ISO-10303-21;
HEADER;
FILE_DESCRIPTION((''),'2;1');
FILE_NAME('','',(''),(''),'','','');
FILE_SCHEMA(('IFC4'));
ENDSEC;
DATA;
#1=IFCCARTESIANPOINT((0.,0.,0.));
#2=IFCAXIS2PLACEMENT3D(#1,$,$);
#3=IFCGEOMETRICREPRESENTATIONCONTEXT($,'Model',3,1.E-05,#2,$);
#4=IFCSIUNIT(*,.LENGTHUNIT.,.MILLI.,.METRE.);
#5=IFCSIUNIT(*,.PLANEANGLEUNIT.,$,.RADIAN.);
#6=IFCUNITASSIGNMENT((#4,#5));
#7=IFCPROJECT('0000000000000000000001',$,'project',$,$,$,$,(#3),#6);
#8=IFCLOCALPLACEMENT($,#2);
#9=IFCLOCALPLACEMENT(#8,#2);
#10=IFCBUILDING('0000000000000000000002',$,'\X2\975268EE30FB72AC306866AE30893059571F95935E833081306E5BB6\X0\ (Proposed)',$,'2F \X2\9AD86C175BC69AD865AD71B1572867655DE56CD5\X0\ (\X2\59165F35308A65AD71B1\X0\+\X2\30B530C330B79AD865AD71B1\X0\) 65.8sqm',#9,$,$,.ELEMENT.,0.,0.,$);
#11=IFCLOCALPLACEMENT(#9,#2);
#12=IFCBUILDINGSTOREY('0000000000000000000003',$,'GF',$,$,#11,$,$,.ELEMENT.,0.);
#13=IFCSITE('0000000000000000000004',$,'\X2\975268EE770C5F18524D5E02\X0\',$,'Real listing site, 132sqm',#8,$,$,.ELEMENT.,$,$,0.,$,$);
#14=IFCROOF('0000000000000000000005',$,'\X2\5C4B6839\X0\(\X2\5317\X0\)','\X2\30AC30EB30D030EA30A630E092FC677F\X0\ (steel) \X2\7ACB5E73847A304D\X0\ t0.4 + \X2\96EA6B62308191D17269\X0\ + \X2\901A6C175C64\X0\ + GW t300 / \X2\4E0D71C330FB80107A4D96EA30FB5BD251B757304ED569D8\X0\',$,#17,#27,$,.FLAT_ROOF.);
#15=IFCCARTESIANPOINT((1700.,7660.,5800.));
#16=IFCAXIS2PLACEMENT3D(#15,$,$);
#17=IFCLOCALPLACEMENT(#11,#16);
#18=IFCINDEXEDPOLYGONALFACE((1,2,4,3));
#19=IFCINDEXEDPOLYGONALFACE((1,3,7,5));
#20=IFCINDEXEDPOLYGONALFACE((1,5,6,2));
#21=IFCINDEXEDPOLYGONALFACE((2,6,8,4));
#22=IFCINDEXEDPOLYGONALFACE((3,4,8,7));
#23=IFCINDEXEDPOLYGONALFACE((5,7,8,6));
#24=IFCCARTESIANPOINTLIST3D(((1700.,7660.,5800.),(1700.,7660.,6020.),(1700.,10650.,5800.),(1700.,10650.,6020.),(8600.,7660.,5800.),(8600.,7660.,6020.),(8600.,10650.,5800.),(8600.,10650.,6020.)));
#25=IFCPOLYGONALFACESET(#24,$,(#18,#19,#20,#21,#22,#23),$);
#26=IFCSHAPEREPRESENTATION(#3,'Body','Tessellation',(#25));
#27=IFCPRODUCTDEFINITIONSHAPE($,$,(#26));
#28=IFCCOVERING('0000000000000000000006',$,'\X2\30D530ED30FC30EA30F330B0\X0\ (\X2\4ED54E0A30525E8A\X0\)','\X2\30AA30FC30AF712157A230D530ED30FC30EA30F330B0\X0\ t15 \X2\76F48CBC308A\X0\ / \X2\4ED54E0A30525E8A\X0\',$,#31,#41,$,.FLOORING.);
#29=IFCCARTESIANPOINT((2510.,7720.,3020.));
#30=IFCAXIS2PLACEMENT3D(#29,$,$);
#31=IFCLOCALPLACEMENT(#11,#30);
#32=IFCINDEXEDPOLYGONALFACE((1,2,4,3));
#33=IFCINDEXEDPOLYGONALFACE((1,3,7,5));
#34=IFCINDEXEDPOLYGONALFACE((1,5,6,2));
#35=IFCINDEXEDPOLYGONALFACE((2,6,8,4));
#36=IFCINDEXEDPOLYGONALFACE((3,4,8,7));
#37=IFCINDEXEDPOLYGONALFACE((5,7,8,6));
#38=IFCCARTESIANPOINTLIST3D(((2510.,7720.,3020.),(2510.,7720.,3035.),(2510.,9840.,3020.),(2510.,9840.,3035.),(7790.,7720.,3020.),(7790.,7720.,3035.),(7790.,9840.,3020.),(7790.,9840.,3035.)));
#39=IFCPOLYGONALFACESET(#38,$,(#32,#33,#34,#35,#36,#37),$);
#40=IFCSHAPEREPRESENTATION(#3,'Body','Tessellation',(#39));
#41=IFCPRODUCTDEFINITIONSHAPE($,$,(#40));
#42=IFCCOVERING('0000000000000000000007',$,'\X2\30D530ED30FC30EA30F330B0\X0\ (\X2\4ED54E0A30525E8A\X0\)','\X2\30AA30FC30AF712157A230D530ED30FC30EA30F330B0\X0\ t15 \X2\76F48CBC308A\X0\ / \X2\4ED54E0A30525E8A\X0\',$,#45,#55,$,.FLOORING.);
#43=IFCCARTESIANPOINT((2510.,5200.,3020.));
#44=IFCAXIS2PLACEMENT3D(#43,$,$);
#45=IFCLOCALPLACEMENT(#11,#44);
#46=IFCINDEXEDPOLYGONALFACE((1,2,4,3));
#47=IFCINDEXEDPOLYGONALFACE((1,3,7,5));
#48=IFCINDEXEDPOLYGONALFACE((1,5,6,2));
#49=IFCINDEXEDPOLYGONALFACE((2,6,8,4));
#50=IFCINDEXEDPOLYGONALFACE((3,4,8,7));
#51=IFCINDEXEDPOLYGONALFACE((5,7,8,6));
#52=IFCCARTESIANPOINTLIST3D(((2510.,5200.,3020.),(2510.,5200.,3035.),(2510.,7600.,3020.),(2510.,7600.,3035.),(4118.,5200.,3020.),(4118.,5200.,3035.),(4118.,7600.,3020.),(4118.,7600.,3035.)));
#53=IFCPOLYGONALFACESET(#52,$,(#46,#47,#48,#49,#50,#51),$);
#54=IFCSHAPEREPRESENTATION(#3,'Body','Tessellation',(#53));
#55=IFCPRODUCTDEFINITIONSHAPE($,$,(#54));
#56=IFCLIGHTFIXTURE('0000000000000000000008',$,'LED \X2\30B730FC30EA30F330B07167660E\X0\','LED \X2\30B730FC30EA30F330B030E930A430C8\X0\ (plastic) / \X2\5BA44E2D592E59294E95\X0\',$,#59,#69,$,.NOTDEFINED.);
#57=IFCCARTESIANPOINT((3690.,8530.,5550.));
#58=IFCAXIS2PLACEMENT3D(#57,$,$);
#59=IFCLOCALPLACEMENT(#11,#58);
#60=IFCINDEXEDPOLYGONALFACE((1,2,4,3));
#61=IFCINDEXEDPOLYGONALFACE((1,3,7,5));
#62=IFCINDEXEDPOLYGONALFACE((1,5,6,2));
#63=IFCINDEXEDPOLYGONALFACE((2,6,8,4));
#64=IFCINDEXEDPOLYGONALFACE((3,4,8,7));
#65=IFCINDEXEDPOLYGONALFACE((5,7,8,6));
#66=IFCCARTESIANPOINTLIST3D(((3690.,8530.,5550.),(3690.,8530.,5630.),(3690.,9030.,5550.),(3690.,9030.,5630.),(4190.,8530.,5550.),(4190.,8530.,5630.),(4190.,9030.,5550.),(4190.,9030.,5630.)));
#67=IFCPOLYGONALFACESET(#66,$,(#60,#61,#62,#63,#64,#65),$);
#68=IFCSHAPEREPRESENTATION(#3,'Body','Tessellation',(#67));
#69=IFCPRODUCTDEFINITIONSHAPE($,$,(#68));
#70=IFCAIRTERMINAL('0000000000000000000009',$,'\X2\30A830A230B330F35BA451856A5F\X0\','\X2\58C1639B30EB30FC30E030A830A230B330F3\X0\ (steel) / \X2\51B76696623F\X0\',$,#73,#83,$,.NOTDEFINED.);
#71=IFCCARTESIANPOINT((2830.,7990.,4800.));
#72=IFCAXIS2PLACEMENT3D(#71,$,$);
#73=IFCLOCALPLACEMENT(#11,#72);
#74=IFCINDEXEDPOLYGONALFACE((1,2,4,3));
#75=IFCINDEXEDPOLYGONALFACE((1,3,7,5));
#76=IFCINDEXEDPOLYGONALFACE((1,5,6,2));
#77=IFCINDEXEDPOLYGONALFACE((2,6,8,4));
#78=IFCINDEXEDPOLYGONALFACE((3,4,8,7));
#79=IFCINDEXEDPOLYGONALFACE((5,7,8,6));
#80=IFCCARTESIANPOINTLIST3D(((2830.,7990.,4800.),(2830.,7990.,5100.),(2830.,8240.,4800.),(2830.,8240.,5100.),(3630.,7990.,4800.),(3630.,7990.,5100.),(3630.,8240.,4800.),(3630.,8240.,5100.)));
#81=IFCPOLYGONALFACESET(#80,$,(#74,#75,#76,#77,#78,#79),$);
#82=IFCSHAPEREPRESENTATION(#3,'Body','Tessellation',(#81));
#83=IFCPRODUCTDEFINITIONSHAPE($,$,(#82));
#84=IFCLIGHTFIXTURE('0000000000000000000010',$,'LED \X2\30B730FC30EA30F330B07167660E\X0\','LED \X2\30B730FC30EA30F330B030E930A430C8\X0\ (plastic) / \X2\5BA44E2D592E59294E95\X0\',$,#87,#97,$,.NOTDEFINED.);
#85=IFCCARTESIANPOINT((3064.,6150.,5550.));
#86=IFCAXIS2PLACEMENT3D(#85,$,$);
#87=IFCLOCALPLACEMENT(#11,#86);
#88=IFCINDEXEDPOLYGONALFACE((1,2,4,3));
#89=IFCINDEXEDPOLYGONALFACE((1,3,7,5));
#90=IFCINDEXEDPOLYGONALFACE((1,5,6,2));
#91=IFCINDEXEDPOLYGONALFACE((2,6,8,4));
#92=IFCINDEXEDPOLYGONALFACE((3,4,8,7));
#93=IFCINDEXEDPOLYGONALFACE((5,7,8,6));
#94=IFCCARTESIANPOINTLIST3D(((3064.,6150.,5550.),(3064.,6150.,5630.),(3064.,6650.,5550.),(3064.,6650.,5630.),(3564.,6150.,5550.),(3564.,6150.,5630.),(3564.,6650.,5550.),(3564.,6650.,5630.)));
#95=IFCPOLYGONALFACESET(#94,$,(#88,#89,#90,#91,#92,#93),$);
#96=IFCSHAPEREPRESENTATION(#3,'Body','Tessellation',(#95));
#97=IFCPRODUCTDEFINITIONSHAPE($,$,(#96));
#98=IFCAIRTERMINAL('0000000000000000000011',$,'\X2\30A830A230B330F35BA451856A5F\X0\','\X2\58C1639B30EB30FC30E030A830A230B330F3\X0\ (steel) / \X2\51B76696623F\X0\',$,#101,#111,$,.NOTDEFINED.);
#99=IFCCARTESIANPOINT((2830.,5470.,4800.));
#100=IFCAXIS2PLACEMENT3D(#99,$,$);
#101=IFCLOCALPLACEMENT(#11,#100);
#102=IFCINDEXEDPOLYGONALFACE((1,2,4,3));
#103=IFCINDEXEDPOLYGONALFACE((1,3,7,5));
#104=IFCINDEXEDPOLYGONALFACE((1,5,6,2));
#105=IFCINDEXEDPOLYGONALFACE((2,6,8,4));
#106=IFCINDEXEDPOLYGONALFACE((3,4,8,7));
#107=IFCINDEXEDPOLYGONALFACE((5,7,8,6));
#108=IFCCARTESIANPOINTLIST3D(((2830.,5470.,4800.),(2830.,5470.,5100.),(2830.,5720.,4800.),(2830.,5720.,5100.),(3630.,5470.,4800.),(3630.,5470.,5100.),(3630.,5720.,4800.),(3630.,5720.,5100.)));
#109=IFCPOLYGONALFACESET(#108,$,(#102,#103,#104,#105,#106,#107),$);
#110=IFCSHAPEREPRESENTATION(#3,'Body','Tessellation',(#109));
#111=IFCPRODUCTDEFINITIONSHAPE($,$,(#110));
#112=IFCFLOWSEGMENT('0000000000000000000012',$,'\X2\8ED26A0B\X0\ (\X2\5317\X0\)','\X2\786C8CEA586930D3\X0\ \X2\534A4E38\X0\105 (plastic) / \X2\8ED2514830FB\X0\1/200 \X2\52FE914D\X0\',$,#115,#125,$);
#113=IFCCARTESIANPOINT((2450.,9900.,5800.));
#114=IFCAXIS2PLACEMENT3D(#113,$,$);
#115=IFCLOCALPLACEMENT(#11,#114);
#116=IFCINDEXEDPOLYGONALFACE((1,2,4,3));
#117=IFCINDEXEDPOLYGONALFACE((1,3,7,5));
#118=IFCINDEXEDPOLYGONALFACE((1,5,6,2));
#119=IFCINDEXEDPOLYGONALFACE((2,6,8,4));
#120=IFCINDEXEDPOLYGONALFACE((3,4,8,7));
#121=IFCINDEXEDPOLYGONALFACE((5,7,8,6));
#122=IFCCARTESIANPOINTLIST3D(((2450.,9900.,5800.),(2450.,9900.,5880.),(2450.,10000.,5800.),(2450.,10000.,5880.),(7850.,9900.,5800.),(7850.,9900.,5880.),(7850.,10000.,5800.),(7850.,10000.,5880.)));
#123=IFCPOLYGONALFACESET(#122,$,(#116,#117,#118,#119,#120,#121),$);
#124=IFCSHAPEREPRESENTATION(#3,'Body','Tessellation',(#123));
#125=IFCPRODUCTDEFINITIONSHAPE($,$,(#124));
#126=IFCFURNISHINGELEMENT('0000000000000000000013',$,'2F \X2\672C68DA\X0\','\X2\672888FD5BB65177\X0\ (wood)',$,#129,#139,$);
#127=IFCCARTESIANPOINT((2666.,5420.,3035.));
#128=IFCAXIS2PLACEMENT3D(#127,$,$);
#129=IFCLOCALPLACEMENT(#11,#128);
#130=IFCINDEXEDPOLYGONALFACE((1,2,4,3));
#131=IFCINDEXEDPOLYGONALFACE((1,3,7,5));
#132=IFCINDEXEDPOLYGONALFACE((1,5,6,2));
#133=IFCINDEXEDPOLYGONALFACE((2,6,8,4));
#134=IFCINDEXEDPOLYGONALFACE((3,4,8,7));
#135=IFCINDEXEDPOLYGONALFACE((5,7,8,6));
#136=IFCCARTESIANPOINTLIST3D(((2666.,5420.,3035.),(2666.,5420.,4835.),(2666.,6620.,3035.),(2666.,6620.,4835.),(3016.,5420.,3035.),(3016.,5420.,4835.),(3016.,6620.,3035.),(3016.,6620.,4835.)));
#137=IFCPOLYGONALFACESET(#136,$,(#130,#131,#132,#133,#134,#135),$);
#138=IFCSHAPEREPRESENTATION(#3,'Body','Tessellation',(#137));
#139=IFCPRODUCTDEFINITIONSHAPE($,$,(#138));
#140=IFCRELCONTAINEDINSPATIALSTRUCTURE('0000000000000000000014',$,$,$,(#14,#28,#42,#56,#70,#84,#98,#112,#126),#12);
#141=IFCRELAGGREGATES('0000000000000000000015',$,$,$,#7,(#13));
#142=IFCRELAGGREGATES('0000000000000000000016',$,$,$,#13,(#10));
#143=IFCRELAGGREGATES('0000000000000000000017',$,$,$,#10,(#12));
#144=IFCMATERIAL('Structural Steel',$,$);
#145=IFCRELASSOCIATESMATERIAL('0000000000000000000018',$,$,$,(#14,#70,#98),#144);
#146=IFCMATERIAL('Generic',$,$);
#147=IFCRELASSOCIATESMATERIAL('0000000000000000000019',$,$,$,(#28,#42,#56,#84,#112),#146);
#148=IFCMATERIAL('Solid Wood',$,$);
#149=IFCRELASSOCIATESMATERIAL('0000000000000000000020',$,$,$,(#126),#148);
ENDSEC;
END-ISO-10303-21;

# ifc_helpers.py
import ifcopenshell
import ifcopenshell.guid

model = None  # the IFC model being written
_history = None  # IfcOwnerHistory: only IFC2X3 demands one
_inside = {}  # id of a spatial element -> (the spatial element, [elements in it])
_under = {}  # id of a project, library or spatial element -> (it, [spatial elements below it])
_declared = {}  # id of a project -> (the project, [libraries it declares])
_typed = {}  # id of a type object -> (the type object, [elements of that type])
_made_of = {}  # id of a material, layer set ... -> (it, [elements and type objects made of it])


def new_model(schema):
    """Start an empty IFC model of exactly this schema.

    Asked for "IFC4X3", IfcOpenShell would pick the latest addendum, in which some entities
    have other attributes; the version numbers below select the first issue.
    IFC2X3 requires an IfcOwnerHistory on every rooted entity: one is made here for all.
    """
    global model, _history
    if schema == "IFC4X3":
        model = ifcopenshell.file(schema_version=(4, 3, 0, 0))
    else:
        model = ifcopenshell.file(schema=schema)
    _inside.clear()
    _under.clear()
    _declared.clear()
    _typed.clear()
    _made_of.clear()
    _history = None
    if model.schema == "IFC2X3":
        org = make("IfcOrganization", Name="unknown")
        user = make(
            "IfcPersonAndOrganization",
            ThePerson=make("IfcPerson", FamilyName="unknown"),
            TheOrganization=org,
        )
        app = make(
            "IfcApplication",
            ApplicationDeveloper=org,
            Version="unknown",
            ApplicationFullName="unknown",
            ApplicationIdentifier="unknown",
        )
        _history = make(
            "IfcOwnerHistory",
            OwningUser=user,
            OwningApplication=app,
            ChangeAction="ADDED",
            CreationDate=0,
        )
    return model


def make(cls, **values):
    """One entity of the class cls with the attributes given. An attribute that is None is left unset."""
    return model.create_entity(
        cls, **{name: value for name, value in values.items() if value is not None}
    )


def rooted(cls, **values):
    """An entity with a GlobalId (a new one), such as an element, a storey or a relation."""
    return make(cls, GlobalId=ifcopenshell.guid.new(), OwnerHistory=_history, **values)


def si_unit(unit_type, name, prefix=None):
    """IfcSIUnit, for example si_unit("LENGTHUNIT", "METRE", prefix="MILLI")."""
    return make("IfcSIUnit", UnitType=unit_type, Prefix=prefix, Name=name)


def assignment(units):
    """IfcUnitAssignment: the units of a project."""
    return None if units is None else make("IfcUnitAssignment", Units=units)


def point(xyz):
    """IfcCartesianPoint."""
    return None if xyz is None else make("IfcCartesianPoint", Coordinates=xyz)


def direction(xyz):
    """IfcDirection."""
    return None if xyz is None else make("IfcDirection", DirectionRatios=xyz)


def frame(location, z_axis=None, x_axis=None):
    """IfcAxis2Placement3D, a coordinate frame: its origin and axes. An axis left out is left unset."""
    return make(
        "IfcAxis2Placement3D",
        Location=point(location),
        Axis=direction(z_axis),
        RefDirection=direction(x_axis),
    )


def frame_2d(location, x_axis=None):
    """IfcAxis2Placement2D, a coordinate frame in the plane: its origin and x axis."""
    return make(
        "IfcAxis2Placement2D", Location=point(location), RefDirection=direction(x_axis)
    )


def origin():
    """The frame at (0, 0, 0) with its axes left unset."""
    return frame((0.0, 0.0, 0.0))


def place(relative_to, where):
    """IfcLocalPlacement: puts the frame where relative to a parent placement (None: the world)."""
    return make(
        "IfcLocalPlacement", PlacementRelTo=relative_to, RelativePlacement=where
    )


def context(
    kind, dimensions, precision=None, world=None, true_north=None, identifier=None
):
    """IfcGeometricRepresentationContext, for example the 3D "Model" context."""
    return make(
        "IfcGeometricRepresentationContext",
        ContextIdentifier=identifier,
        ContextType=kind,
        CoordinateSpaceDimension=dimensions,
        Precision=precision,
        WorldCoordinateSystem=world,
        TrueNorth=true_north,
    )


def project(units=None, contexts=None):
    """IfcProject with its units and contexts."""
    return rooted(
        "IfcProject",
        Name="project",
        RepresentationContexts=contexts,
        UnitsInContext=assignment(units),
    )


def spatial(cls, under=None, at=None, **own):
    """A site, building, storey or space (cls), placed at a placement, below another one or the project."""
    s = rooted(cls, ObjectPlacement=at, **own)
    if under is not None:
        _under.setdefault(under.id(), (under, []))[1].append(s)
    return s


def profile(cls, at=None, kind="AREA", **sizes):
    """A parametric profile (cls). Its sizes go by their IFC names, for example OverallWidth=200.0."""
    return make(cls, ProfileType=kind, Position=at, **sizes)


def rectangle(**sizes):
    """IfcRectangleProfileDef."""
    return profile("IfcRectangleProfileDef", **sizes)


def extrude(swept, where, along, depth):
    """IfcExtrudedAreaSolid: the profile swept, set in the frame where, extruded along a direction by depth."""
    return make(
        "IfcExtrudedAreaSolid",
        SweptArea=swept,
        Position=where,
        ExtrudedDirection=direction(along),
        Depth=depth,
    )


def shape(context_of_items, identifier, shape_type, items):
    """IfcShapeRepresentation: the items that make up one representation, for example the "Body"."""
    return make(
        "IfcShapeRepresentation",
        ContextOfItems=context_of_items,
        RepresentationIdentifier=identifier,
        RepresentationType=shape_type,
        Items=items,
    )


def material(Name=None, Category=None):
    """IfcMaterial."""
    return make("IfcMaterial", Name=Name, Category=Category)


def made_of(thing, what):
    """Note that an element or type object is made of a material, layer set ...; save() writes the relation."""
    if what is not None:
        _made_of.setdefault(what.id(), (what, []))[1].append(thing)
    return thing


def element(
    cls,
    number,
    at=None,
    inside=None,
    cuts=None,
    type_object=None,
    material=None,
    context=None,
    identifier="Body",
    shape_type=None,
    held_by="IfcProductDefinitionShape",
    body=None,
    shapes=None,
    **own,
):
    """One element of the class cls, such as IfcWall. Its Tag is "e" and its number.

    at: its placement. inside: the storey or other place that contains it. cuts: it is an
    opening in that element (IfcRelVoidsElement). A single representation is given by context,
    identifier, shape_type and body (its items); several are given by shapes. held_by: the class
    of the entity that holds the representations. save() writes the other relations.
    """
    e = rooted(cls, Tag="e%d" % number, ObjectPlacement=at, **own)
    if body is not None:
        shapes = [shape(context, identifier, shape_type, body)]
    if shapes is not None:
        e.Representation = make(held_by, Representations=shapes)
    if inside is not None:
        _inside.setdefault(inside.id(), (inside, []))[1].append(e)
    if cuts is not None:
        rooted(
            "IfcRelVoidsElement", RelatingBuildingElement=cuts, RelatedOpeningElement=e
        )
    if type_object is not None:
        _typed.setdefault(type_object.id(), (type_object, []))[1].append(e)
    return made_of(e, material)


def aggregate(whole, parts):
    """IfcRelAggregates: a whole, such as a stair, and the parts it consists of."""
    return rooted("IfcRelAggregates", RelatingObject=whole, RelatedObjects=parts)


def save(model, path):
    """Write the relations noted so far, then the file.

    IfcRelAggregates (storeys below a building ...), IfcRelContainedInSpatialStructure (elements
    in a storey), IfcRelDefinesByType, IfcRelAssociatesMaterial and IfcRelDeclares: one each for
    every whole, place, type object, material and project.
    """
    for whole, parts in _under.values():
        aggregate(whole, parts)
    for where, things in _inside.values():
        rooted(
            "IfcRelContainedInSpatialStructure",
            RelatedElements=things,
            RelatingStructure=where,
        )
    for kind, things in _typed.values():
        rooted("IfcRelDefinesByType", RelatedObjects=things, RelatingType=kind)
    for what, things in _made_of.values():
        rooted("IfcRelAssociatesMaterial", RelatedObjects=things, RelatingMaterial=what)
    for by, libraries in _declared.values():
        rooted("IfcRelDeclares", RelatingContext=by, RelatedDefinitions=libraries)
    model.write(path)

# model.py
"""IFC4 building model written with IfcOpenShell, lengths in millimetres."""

from ifc_helpers import new_model, si_unit, frame, frame_2d, origin, place, context, project, spatial, rectangle, extrude, material, element, save


model = new_model("IFC4")

# Units and contexts
model_context = context("Model", 3, precision=1e-05, world=origin())
ifc_project = project(units=[si_unit("LENGTHUNIT", "METRE", prefix="MILLI"), si_unit("PLANEANGLEUNIT", "RADIAN")], contexts=[model_context])

# Site, building, storey
site_placement = place(None, origin())
site = spatial("IfcSite", under=ifc_project, at=site_placement, Name="青森県弘前市", ObjectType="Real listing site, 132sqm", CompositionType="ELEMENT", RefElevation=0.0)
building_placement = place(site_placement, origin())
building = spatial("IfcBuilding", under=site, at=building_placement, Name="青森・犬と暮らす土間広めの家 (Proposed)", ObjectType="2F 高気密高断熱在来工法 (外張り断熱+サッシ高断熱) 65.8sqm", CompositionType="ELEMENT", ElevationOfRefHeight=0.0, ElevationOfTerrain=0.0)
storey_placement = place(building_placement, origin())
storey = spatial("IfcBuildingStorey", under=building, at=storey_placement, Name="GF", CompositionType="ELEMENT", Elevation=0.0)

# Shared definitions
ifc_material_1 = material(Name="Solid Wood")

# Roof
ifc_material_2 = material(Name="Structural Steel")
for number, where, name in (
    (1, (1700.0, 7660.0, 5800.0), "屋根(北)"),
):
    element("IfcRoof", number, at=place(storey_placement, frame(where)), inside=storey, material=ifc_material_2, Name=name, Description="ガルバリウム鋼板 (steel) 立平葺き t0.4 + 雪止め金物 + 通気層 + GW t300 / 不燃・耐積雪・寒冷地仕様", PredefinedType="FLAT_ROOF", context=model_context, shape_type="SweptSolid", body=[
        extrude(rectangle(XDim=6900.0, YDim=2990.0, at=frame_2d((3450.0, 1495.0))), frame((1700.0, 7660.0, 5800.0)), (0.0, 0.0, 1.0), 220.0),
    ])

# Coverings
ifc_material_3 = material(Name="Generic")
covering_1_placement = place(storey_placement, frame((2510.0, 7720.0, 3020.0)))
element("IfcCovering", 2, at=covering_1_placement, inside=storey, material=ifc_material_3, Name="フローリング (仕上げ床)", Description="オーク無垢フローリング t15 直貼り / 仕上げ床", PredefinedType="FLOORING", context=model_context, shape_type="SweptSolid", body=[
    extrude(rectangle(XDim=5280.0, YDim=2120.0, at=frame_2d((2640.0, 1060.0))), frame((2510.0, 7720.0, 3020.0)), (0.0, 0.0, 1.0), 15.0),
])
covering_2_placement = place(storey_placement, frame((2510.0, 5200.0, 3020.0)))
element("IfcCovering", 3, at=covering_2_placement, inside=storey, material=ifc_material_3, Name="フローリング (仕上げ床)", Description="オーク無垢フローリング t15 直貼り / 仕上げ床", PredefinedType="FLOORING", context=model_context, shape_type="SweptSolid", body=[
    extrude(rectangle(XDim=1608.0, YDim=2400.0, at=frame_2d((804.0, 1200.0))), frame((2510.0, 5200.0, 3020.0)), (0.0, 0.0, 1.0), 15.0),
])

# Light fixture
light_fixture_1_placement = place(storey_placement, frame((3690.0, 8530.0, 5550.0)))
element("IfcLightFixture", 4, at=light_fixture_1_placement, inside=storey, material=ifc_material_3, Name="LED シーリング照明", Description="LED シーリングライト (plastic) / 室中央天井", PredefinedType="NOTDEFINED", context=model_context, shape_type="SweptSolid", body=[
    extrude(rectangle(XDim=500.0, YDim=500.0, at=frame_2d((250.0, 250.0))), frame((3690.0, 8530.0, 5550.0)), (0.0, 0.0, 1.0), 80.0),
])

# Air terminal
air_terminal_1_placement = place(storey_placement, frame((2830.0, 7990.0, 4800.0)))
element("IfcAirTerminal", 5, at=air_terminal_1_placement, inside=storey, material=ifc_material_2, Name="エアコン室内機", Description="壁掛ルームエアコン (steel) / 冷暖房", PredefinedType="NOTDEFINED", context=model_context, shape_type="SweptSolid", body=[
    extrude(rectangle(XDim=800.0, YDim=250.0, at=frame_2d((400.0, 125.0))), frame((2830.0, 7990.0, 4800.0)), (0.0, 0.0, 1.0), 300.0),
])

# Light fixture
light_fixture_2_placement = place(storey_placement, frame((3064.0, 6150.0, 5550.0)))
element("IfcLightFixture", 6, at=light_fixture_2_placement, inside=storey, material=ifc_material_3, Name="LED シーリング照明", Description="LED シーリングライト (plastic) / 室中央天井", PredefinedType="NOTDEFINED", context=model_context, shape_type="SweptSolid", body=[
    extrude(rectangle(XDim=500.0, YDim=500.0, at=frame_2d((250.0, 250.0))), frame((3064.0, 6150.0, 5550.0)), (0.0, 0.0, 1.0), 80.0),
])

# Air terminal
air_terminal_2_placement = place(storey_placement, frame((2830.0, 5470.0, 4800.0)))
element("IfcAirTerminal", 7, at=air_terminal_2_placement, inside=storey, material=ifc_material_2, Name="エアコン室内機", Description="壁掛ルームエアコン (steel) / 冷暖房", PredefinedType="NOTDEFINED", context=model_context, shape_type="SweptSolid", body=[
    extrude(rectangle(XDim=800.0, YDim=250.0, at=frame_2d((400.0, 125.0))), frame((2830.0, 5470.0, 4800.0)), (0.0, 0.0, 1.0), 300.0),
])

# Flow segment
flow_segment_placement = place(storey_placement, frame((2450.0, 9900.0, 5800.0)))
element("IfcFlowSegment", 8, at=flow_segment_placement, inside=storey, material=ifc_material_3, Name="軒樋 (北)", Description="硬質塩ビ 半丸105 (plastic) / 軒先・1/200 勾配", context=model_context, shape_type="SweptSolid", body=[
    extrude(rectangle(XDim=5400.0, YDim=100.0, at=frame_2d((2700.0, 50.0))), frame((2450.0, 9900.0, 5800.0)), (0.0, 0.0, 1.0), 80.0),
])

# Furnishing element
furnishing_placement = place(storey_placement, frame((2666.0, 5420.0, 3035.0)))
element("IfcFurnishingElement", 9, at=furnishing_placement, inside=storey, material=ifc_material_1, Name="2F 本棚", Description="木製家具 (wood)", context=model_context, shape_type="SweptSolid", body=[
    extrude(rectangle(XDim=350.0, YDim=1200.0, at=frame_2d((175.0, 600.0))), frame((2666.0, 5420.0, 3035.0)), (0.0, 0.0, 1.0), 1800.0),
])

save(model, "model.ifc")
